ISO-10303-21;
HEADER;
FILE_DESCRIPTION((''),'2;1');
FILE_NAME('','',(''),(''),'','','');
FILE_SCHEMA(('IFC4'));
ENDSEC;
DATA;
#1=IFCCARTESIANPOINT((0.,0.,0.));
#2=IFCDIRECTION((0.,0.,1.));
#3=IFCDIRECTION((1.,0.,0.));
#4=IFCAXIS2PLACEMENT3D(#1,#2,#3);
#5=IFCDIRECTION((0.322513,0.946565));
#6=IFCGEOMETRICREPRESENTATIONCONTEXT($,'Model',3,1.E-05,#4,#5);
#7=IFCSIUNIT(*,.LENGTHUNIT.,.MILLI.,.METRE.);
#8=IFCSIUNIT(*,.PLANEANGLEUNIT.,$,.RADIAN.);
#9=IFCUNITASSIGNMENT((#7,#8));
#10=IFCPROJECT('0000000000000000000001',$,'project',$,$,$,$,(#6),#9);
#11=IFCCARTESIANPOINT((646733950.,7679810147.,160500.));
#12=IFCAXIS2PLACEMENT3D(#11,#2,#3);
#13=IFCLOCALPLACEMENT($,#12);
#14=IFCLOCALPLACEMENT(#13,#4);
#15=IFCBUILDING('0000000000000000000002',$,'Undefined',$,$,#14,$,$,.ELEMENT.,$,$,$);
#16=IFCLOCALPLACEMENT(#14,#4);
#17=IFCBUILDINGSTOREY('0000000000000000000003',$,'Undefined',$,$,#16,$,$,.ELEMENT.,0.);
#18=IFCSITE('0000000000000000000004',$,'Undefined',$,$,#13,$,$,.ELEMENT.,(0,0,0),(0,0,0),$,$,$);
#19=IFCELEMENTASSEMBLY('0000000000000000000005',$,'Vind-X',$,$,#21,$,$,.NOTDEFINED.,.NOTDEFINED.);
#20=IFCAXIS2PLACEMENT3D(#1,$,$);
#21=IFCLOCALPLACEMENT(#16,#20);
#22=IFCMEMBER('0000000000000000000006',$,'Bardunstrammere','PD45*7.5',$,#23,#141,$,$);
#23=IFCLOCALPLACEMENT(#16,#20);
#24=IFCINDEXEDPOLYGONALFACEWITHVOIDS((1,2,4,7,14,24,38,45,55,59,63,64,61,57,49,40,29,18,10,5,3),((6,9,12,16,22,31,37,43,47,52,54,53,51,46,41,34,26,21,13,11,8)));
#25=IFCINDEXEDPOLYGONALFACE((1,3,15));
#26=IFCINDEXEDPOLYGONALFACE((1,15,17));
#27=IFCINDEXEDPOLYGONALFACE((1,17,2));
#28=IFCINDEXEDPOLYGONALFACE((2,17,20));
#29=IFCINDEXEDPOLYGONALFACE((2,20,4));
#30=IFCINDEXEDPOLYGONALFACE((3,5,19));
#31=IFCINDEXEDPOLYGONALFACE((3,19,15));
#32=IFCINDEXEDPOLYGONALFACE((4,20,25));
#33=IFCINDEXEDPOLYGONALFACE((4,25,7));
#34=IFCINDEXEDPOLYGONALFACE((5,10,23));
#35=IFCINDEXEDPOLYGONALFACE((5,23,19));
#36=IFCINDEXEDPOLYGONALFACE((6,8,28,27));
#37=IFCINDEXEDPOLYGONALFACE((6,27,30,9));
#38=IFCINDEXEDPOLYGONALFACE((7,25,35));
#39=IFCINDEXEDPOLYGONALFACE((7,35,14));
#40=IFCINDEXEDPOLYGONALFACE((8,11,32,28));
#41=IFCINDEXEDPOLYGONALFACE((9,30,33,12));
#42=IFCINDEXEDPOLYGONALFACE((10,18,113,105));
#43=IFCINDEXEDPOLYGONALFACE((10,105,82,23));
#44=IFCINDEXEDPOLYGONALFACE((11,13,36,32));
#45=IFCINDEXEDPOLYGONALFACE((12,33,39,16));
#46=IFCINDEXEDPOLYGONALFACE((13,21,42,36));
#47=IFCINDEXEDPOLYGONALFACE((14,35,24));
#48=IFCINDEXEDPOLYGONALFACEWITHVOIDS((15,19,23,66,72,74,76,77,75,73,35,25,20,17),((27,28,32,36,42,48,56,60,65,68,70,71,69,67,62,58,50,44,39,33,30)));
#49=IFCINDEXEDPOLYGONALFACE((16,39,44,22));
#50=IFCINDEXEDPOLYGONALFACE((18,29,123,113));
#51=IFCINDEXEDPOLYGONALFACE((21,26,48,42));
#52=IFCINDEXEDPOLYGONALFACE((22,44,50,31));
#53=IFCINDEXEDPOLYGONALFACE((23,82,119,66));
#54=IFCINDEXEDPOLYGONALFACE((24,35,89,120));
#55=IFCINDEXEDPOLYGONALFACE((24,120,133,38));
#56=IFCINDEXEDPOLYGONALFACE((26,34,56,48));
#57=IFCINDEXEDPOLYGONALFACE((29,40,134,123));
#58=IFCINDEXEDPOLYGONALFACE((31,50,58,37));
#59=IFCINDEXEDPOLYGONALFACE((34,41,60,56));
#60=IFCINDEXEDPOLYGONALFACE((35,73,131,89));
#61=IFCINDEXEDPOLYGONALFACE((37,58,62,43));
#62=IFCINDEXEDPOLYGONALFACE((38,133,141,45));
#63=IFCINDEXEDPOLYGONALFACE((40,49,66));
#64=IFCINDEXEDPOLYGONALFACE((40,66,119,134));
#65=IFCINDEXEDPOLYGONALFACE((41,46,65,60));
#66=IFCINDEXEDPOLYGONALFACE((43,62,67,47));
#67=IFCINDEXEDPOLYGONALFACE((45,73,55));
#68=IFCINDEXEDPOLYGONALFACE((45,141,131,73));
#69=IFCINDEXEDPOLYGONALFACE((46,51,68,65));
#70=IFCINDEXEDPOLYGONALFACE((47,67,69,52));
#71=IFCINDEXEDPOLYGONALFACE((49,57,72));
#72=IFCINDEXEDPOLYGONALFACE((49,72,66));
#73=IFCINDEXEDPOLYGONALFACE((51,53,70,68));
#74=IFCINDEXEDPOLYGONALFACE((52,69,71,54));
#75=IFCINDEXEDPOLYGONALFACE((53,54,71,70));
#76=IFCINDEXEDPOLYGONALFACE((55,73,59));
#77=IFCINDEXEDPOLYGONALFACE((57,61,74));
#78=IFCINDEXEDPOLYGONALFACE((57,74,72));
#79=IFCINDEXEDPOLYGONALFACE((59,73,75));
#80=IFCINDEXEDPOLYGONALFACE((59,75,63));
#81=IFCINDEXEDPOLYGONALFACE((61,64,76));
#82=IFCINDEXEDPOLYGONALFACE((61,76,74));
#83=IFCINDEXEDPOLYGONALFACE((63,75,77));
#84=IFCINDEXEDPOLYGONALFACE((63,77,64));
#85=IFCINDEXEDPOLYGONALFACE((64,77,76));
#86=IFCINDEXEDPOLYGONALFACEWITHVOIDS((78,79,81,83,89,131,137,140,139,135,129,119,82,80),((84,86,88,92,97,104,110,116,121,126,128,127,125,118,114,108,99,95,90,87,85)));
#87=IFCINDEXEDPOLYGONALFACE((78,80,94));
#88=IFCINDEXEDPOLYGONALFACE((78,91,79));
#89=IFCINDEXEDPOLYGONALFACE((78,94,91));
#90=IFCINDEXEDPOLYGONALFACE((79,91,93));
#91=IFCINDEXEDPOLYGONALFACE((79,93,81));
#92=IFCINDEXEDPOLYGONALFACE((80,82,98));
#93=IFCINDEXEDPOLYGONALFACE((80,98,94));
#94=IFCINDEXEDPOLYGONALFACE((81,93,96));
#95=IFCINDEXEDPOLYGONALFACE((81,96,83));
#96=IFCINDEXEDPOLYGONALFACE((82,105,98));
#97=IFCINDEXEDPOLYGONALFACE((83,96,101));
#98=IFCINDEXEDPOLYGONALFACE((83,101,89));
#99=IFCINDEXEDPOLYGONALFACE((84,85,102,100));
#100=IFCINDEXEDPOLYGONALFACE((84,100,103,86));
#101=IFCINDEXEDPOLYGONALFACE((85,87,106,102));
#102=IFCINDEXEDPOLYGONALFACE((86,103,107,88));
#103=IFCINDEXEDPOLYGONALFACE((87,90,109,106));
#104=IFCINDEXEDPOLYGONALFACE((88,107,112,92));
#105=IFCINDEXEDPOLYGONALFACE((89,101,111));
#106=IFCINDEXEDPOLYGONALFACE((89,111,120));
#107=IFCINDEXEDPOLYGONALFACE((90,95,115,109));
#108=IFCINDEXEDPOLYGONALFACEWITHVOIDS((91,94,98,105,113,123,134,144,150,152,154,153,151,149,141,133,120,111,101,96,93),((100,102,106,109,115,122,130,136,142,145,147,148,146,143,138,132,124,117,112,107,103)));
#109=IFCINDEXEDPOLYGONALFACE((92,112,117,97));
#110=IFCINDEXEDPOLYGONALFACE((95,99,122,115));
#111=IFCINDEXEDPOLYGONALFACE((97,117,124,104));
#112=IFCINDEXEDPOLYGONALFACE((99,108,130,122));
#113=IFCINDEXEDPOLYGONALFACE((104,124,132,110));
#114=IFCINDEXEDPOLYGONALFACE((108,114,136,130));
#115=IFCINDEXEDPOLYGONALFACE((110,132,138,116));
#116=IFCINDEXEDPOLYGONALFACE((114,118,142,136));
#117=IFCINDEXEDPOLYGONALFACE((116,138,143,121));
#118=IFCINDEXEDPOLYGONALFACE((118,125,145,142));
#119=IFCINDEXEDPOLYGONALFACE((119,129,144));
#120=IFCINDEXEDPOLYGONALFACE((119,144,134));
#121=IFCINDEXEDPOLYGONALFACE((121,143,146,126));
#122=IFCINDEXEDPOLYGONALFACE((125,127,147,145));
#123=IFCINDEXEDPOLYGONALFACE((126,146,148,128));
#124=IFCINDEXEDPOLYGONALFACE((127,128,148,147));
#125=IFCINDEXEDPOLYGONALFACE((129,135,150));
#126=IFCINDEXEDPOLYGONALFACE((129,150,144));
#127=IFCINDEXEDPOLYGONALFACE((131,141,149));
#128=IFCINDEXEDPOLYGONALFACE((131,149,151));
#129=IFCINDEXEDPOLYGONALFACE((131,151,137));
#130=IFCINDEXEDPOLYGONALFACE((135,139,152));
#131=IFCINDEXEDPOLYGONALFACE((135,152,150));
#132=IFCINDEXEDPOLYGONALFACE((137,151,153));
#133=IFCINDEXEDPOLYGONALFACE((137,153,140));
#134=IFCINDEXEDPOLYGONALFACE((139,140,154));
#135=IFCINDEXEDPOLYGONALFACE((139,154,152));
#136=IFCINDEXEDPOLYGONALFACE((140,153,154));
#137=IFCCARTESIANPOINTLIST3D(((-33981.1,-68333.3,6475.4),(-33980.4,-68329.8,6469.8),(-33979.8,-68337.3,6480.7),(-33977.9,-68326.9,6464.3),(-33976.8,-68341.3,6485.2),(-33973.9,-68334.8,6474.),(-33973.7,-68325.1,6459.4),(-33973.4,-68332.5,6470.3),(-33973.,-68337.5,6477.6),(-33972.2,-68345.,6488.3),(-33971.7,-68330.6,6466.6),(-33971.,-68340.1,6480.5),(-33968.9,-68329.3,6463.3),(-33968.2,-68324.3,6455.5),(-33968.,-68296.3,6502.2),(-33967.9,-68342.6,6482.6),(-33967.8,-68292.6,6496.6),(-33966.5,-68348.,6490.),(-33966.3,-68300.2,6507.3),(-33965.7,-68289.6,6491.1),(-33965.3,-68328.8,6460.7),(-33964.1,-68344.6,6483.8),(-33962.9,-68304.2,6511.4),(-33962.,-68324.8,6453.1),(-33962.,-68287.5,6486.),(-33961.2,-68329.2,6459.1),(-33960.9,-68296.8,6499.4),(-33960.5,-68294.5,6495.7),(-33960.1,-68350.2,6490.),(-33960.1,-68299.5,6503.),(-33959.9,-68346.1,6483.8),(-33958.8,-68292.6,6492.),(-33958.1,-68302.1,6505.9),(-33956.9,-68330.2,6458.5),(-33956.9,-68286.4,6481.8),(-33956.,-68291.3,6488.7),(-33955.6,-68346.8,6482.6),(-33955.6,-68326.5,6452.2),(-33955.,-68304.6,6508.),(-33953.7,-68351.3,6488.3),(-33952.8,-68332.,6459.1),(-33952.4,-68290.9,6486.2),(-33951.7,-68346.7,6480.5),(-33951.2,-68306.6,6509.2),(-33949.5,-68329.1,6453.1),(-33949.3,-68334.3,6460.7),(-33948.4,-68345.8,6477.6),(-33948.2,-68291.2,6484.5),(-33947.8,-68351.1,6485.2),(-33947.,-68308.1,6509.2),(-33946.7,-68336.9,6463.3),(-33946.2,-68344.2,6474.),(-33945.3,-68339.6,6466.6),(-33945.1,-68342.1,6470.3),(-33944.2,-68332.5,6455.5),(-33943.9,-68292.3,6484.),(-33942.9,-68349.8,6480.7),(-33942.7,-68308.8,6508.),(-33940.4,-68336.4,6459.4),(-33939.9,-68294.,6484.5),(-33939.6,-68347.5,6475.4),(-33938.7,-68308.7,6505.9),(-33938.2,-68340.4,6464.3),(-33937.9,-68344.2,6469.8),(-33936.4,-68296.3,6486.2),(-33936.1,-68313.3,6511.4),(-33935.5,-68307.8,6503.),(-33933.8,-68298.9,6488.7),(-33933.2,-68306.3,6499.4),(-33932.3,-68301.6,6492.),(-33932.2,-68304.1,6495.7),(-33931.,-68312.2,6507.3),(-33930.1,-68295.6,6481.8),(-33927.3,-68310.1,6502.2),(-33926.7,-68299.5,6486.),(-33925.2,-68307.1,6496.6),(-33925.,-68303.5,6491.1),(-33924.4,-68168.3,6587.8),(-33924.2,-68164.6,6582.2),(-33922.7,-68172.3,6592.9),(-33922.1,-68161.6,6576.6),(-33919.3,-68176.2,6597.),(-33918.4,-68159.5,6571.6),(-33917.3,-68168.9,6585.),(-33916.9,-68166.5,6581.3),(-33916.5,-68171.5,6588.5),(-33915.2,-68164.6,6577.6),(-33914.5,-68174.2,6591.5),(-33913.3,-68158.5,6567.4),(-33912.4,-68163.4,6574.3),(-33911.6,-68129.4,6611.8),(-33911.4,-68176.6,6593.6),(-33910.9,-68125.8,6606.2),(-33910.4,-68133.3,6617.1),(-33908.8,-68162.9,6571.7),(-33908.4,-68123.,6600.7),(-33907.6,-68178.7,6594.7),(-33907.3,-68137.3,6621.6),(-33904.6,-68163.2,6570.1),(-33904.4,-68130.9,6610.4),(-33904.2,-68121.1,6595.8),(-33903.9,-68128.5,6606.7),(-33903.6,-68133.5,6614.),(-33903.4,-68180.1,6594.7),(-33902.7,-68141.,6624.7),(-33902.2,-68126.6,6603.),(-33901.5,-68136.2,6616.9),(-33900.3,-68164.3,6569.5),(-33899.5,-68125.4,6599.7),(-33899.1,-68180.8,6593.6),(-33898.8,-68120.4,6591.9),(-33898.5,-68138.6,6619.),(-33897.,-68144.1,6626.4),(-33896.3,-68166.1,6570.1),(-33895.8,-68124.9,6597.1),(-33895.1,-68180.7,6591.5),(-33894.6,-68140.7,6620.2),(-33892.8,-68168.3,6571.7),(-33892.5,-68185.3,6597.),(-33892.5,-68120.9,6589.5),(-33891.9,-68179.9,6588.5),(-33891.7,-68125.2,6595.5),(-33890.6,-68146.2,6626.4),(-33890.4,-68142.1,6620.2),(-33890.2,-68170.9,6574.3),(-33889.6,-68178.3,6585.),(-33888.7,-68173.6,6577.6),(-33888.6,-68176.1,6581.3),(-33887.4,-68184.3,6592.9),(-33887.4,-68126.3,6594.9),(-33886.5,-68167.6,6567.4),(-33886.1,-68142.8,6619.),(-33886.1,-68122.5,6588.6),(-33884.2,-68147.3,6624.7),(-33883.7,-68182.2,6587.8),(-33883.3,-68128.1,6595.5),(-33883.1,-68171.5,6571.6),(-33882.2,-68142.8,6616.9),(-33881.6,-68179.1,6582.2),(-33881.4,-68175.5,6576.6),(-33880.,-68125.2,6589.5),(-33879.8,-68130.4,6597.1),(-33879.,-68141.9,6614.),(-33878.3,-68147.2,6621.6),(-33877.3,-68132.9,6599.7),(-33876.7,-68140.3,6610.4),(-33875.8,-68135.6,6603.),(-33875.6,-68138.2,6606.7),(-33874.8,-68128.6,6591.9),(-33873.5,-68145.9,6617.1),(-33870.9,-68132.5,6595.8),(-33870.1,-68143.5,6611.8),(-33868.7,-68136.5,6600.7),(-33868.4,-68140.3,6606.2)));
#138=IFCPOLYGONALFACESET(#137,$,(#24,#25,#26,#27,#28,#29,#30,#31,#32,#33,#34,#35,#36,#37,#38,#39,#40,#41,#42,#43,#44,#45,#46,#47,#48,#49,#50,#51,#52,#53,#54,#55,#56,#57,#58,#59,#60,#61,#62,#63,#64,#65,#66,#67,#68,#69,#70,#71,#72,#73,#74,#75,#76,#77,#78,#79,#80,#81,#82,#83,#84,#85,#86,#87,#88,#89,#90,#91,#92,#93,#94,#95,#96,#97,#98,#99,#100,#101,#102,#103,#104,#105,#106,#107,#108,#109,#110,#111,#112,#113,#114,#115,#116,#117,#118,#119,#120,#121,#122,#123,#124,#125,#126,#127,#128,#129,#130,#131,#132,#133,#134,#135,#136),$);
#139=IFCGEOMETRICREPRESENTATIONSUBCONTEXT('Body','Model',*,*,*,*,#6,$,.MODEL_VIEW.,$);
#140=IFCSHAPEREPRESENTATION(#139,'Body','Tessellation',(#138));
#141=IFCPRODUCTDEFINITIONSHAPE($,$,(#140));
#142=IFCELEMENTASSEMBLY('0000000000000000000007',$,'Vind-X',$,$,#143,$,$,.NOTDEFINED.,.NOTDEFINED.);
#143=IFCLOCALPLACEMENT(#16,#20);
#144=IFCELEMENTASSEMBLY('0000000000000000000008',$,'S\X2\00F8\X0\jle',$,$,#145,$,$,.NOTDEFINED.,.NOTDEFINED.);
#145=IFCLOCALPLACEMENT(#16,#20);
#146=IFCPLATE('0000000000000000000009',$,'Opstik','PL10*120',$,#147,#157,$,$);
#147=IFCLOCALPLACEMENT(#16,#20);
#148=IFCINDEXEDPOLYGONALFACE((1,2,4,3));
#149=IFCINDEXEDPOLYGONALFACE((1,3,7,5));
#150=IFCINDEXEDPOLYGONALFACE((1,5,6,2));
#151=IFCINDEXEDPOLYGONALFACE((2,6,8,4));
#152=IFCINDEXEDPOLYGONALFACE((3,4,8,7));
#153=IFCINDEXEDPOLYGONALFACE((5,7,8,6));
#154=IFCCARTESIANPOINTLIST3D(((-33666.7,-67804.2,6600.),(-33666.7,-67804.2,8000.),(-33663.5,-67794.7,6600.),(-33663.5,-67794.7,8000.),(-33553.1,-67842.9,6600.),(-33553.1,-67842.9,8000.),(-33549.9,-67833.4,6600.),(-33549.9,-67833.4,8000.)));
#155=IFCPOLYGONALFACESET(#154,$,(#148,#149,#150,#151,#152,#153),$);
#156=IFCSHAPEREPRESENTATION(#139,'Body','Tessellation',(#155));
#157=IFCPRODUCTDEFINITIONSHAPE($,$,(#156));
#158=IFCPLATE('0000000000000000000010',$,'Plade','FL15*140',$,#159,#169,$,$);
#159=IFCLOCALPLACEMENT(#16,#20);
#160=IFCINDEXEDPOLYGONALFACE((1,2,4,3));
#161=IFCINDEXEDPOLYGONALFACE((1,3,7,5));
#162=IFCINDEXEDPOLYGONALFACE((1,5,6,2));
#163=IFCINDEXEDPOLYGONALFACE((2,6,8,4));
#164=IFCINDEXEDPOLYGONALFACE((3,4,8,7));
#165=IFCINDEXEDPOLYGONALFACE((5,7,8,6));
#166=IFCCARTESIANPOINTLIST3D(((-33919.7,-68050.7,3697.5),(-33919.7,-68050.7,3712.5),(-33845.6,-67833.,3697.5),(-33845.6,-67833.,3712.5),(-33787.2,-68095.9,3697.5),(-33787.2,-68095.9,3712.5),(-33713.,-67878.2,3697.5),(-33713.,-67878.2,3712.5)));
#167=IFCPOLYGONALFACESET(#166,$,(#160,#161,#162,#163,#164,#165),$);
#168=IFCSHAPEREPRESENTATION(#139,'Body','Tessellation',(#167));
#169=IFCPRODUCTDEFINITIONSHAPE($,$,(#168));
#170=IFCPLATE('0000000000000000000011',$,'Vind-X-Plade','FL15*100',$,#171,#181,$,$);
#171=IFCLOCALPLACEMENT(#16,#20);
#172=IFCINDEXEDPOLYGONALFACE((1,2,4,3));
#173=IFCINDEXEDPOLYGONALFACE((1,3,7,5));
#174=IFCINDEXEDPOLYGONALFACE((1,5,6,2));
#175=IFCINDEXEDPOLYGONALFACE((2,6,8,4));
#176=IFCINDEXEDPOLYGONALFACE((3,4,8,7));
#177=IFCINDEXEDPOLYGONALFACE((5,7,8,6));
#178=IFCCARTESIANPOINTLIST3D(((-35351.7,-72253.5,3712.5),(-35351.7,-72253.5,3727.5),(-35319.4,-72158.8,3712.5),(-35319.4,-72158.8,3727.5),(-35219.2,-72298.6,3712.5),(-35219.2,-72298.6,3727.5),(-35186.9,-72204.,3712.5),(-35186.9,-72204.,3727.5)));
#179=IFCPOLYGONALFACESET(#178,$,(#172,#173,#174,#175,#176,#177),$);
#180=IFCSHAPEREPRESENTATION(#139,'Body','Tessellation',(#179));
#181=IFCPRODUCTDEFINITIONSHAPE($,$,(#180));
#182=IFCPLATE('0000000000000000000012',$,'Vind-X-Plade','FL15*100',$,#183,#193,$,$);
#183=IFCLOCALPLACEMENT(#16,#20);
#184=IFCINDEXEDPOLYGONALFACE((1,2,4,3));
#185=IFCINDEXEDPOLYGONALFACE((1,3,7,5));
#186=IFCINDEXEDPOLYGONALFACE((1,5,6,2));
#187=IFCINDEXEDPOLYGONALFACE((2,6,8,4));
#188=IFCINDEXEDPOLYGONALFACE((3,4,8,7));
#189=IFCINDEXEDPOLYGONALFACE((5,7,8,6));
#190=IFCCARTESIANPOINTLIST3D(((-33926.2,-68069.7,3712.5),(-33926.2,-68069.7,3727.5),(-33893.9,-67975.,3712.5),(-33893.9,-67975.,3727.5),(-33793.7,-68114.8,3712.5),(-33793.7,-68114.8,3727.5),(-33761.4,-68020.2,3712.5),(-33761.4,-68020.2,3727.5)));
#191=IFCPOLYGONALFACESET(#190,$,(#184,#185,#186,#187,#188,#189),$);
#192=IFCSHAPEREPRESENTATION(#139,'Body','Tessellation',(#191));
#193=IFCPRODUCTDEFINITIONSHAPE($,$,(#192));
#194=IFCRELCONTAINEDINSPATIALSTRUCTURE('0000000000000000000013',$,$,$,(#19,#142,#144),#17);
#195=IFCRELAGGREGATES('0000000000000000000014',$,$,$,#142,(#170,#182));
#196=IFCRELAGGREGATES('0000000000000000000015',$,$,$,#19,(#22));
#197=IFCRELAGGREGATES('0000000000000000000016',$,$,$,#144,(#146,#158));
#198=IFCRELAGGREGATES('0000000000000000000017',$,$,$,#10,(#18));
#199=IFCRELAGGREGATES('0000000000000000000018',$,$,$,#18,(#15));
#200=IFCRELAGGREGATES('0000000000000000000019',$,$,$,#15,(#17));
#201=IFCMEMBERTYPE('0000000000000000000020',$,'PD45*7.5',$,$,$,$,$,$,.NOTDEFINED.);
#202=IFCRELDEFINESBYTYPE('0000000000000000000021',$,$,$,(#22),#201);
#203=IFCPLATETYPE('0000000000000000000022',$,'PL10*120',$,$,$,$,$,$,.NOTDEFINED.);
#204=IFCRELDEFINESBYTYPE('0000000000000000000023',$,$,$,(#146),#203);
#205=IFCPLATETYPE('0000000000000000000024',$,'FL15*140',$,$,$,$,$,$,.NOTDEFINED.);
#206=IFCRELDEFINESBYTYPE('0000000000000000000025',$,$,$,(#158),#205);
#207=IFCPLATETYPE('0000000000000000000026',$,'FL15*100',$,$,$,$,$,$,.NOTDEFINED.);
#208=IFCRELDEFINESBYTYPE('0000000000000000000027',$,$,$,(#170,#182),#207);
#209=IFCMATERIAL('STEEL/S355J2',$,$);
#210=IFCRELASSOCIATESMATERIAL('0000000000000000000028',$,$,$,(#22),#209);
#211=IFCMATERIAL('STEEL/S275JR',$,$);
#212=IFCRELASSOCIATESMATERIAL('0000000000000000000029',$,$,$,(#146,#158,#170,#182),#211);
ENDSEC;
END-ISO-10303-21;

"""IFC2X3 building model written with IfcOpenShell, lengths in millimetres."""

from ifc_helpers import new_model, si_unit, direction, frame, origin_with_axes, origin_2d_with_axis, place, context, subcontext, project, spatial, polyline, rectangle, hollow_circle, outline, extrude, boolean, material, type_object, element, aggregate, save


model = new_model("IFC2X3")

# Units and contexts
model_context = context("Model", 3, precision=1e-05, world=origin_with_axes(), true_north=direction((0.322513, 0.946565)))
body_context = subcontext(model_context, "Body", "Model", "MODEL_VIEW")
ifc_project = project(units=[si_unit("LENGTHUNIT", "METRE", prefix="MILLI"), si_unit("PLANEANGLEUNIT", "RADIAN")], contexts=[model_context])

# Site, building, storey
site_placement = place(None, frame((646733950.0, 7679810147.0, 160500.0), z_axis=(0.0, 0.0, 1.0), x_axis=(1.0, 0.0, 0.0)))
site = spatial("IfcSite", under=ifc_project, at=site_placement, Name="Undefined", CompositionType="ELEMENT", RefLatitude=(0, 0, 0), RefLongitude=(0, 0, 0))
building_placement = place(site_placement, origin_with_axes())
building = spatial("IfcBuilding", under=site, at=building_placement, Name="Undefined", CompositionType="ELEMENT")
storey_placement = place(building_placement, origin_with_axes())
storey = spatial("IfcBuildingStorey", under=building, at=storey_placement, Name="Undefined", CompositionType="ELEMENT", Elevation=0.0)

# Element assembly
ifc_material_1 = material(Name="STEEL/S355J2")
assembly_1_placement = place(storey_placement, origin_with_axes())
assembly_1 = element("IfcElementAssembly", 1, at=assembly_1_placement, inside=storey, Name="Vind-X", AssemblyPlace="NOTDEFINED", PredefinedType="NOTDEFINED")

# Member
member_type_1 = type_object("IfcMemberType", Name="PD45*7.5", PredefinedType="NOTDEFINED")
member_1_placement = place(assembly_1_placement, frame((-33890.0, -68133.9, 6607.6), z_axis=(-0.946565, 0.322513, 0.0), x_axis=(-0.272496, -0.799767, -0.5349)))
member_1 = element("IfcMember", 2, at=member_1_placement, type_object=member_type_1, material=ifc_material_1, Name="Bardunstrammere", Description="PD45*7.5", context=body_context, shape_type="CSG", body=[
    boolean("DIFFERENCE", extrude(hollow_circle(Radius=22.5, WallThickness=7.5, at=origin_2d_with_axis()), frame((255.0, 0.0, 0.0), z_axis=(-1.0, 0.0, 0.0), x_axis=(0.0, -1.0, 0.0)), (0.0, 0.0, 1.0), 255.0), extrude(rectangle(XDim=35.0, YDim=90.0, at=origin_2d_with_axis()), frame((207.5, 0.0, 0.0), z_axis=(-1.0, 0.0, 0.0), x_axis=(0.0, -1.0, 0.0)), (0.0, 0.0, 1.0), 160.0)),
])

# Element assembly
assembly_2_placement = place(storey_placement, origin_with_axes())
assembly_2 = element("IfcElementAssembly", 3, at=assembly_2_placement, inside=storey, Name="Vind-X", AssemblyPlace="NOTDEFINED", PredefinedType="NOTDEFINED")

# Element assembly, plates
assembly_3_placement = place(storey_placement, origin_with_axes())
assembly_3 = element("IfcElementAssembly", 4, at=assembly_3_placement, inside=storey, Name="Søjle", AssemblyPlace="NOTDEFINED", PredefinedType="NOTDEFINED")
ifc_material_2 = material(Name="STEEL/S275JR")
plate_type_1 = type_object("IfcPlateType", Name="PL10*120", PredefinedType="NOTDEFINED")
plate_1_placement = place(assembly_3_placement, frame((-33665.1, -67799.4, 6600.0), z_axis=(0.322513, 0.946565, 0.0), x_axis=(0.0, 0.0, 1.0)))
plate_1 = element("IfcPlate", 5, at=plate_1_placement, type_object=plate_type_1, material=ifc_material_2, Name="Opstik", Description="PL10*120", context=body_context, shape_type="SweptSolid", body=[
    extrude(outline(polyline([(0.0, 0.0), (1400.0, 0.0), (1400.0, 120.0), (1400.0, 120.0), (0.0, 120.0), (0.0, 120.0), (0.0, 0.0)])), frame((0.0, 0.0, -5.0), z_axis=(0.0, 0.0, 1.0), x_axis=(1.0, 0.0, 0.0)), (0.0, 0.0, 1.0), 10.0),
])
plate_type_2 = type_object("IfcPlateType", Name="FL15*140", PredefinedType="NOTDEFINED")
plate_2_placement = place(assembly_3_placement, frame((-33713.0, -67878.2, 3705.0), z_axis=(0.0, 0.0, 1.0), x_axis=(-0.946565, 0.322513, 0.0)))
plate_2 = element("IfcPlate", 6, at=plate_2_placement, type_object=plate_type_2, material=ifc_material_2, Name="Plade", Description="FL15*140", context=body_context, shape_type="SweptSolid", body=[
    extrude(outline(polyline([(0.0, 0.0), (140.0, 0.0), (140.0, 230.0), (0.0, 230.0), (0.0, 0.0)])), frame((0.0, 0.0, -7.5), z_axis=(0.0, 0.0, 1.0), x_axis=(1.0, 0.0, 0.0)), (0.0, 0.0, 1.0), 15.0),
])

# Plates
plate_type_3 = type_object("IfcPlateType", Name="FL15*100", PredefinedType="NOTDEFINED")
plate_3_placement = place(assembly_2_placement, frame((-35285.4, -72276.1, 3720.0), z_axis=(0.0, 0.0, -1.0), x_axis=(0.322513, 0.946565, 0.0)))
plate_3 = element("IfcPlate", 7, at=plate_3_placement, type_object=plate_type_3, material=ifc_material_2, Name="Vind-X-Plade", Description="FL15*100", context=body_context, shape_type="SweptSolid", body=[
    extrude(outline(polyline([(0.0, -70.0), (0.0, 70.0), (100.0, 70.0), (100.0, -70.0), (0.0, -70.0)])), frame((0.0, 0.0, -7.5), z_axis=(0.0, 0.0, 1.0), x_axis=(1.0, 0.0, 0.0)), (0.0, 0.0, 1.0), 15.0),
])
plate_4_placement = place(assembly_2_placement, frame((-33827.7, -67997.6, 3720.0), z_axis=(0.0, 0.0, -1.0), x_axis=(-0.322513, -0.946565, 0.0)))
plate_4 = element("IfcPlate", 8, at=plate_4_placement, type_object=plate_type_3, material=ifc_material_2, Name="Vind-X-Plade", Description="FL15*100", context=body_context, shape_type="SweptSolid", body=[
    extrude(outline(polyline([(0.0, -70.0), (0.0, 70.0), (100.0, 70.0), (100.0, -70.0), (0.0, -70.0)])), frame((0.0, 0.0, -7.5), z_axis=(0.0, 0.0, 1.0), x_axis=(1.0, 0.0, 0.0)), (0.0, 0.0, 1.0), 15.0),
])
aggregate(assembly_2, [plate_3, plate_4])

aggregate(assembly_1, [member_1])
aggregate(assembly_3, [plate_1, plate_2])

save(model, "model.ifc")
